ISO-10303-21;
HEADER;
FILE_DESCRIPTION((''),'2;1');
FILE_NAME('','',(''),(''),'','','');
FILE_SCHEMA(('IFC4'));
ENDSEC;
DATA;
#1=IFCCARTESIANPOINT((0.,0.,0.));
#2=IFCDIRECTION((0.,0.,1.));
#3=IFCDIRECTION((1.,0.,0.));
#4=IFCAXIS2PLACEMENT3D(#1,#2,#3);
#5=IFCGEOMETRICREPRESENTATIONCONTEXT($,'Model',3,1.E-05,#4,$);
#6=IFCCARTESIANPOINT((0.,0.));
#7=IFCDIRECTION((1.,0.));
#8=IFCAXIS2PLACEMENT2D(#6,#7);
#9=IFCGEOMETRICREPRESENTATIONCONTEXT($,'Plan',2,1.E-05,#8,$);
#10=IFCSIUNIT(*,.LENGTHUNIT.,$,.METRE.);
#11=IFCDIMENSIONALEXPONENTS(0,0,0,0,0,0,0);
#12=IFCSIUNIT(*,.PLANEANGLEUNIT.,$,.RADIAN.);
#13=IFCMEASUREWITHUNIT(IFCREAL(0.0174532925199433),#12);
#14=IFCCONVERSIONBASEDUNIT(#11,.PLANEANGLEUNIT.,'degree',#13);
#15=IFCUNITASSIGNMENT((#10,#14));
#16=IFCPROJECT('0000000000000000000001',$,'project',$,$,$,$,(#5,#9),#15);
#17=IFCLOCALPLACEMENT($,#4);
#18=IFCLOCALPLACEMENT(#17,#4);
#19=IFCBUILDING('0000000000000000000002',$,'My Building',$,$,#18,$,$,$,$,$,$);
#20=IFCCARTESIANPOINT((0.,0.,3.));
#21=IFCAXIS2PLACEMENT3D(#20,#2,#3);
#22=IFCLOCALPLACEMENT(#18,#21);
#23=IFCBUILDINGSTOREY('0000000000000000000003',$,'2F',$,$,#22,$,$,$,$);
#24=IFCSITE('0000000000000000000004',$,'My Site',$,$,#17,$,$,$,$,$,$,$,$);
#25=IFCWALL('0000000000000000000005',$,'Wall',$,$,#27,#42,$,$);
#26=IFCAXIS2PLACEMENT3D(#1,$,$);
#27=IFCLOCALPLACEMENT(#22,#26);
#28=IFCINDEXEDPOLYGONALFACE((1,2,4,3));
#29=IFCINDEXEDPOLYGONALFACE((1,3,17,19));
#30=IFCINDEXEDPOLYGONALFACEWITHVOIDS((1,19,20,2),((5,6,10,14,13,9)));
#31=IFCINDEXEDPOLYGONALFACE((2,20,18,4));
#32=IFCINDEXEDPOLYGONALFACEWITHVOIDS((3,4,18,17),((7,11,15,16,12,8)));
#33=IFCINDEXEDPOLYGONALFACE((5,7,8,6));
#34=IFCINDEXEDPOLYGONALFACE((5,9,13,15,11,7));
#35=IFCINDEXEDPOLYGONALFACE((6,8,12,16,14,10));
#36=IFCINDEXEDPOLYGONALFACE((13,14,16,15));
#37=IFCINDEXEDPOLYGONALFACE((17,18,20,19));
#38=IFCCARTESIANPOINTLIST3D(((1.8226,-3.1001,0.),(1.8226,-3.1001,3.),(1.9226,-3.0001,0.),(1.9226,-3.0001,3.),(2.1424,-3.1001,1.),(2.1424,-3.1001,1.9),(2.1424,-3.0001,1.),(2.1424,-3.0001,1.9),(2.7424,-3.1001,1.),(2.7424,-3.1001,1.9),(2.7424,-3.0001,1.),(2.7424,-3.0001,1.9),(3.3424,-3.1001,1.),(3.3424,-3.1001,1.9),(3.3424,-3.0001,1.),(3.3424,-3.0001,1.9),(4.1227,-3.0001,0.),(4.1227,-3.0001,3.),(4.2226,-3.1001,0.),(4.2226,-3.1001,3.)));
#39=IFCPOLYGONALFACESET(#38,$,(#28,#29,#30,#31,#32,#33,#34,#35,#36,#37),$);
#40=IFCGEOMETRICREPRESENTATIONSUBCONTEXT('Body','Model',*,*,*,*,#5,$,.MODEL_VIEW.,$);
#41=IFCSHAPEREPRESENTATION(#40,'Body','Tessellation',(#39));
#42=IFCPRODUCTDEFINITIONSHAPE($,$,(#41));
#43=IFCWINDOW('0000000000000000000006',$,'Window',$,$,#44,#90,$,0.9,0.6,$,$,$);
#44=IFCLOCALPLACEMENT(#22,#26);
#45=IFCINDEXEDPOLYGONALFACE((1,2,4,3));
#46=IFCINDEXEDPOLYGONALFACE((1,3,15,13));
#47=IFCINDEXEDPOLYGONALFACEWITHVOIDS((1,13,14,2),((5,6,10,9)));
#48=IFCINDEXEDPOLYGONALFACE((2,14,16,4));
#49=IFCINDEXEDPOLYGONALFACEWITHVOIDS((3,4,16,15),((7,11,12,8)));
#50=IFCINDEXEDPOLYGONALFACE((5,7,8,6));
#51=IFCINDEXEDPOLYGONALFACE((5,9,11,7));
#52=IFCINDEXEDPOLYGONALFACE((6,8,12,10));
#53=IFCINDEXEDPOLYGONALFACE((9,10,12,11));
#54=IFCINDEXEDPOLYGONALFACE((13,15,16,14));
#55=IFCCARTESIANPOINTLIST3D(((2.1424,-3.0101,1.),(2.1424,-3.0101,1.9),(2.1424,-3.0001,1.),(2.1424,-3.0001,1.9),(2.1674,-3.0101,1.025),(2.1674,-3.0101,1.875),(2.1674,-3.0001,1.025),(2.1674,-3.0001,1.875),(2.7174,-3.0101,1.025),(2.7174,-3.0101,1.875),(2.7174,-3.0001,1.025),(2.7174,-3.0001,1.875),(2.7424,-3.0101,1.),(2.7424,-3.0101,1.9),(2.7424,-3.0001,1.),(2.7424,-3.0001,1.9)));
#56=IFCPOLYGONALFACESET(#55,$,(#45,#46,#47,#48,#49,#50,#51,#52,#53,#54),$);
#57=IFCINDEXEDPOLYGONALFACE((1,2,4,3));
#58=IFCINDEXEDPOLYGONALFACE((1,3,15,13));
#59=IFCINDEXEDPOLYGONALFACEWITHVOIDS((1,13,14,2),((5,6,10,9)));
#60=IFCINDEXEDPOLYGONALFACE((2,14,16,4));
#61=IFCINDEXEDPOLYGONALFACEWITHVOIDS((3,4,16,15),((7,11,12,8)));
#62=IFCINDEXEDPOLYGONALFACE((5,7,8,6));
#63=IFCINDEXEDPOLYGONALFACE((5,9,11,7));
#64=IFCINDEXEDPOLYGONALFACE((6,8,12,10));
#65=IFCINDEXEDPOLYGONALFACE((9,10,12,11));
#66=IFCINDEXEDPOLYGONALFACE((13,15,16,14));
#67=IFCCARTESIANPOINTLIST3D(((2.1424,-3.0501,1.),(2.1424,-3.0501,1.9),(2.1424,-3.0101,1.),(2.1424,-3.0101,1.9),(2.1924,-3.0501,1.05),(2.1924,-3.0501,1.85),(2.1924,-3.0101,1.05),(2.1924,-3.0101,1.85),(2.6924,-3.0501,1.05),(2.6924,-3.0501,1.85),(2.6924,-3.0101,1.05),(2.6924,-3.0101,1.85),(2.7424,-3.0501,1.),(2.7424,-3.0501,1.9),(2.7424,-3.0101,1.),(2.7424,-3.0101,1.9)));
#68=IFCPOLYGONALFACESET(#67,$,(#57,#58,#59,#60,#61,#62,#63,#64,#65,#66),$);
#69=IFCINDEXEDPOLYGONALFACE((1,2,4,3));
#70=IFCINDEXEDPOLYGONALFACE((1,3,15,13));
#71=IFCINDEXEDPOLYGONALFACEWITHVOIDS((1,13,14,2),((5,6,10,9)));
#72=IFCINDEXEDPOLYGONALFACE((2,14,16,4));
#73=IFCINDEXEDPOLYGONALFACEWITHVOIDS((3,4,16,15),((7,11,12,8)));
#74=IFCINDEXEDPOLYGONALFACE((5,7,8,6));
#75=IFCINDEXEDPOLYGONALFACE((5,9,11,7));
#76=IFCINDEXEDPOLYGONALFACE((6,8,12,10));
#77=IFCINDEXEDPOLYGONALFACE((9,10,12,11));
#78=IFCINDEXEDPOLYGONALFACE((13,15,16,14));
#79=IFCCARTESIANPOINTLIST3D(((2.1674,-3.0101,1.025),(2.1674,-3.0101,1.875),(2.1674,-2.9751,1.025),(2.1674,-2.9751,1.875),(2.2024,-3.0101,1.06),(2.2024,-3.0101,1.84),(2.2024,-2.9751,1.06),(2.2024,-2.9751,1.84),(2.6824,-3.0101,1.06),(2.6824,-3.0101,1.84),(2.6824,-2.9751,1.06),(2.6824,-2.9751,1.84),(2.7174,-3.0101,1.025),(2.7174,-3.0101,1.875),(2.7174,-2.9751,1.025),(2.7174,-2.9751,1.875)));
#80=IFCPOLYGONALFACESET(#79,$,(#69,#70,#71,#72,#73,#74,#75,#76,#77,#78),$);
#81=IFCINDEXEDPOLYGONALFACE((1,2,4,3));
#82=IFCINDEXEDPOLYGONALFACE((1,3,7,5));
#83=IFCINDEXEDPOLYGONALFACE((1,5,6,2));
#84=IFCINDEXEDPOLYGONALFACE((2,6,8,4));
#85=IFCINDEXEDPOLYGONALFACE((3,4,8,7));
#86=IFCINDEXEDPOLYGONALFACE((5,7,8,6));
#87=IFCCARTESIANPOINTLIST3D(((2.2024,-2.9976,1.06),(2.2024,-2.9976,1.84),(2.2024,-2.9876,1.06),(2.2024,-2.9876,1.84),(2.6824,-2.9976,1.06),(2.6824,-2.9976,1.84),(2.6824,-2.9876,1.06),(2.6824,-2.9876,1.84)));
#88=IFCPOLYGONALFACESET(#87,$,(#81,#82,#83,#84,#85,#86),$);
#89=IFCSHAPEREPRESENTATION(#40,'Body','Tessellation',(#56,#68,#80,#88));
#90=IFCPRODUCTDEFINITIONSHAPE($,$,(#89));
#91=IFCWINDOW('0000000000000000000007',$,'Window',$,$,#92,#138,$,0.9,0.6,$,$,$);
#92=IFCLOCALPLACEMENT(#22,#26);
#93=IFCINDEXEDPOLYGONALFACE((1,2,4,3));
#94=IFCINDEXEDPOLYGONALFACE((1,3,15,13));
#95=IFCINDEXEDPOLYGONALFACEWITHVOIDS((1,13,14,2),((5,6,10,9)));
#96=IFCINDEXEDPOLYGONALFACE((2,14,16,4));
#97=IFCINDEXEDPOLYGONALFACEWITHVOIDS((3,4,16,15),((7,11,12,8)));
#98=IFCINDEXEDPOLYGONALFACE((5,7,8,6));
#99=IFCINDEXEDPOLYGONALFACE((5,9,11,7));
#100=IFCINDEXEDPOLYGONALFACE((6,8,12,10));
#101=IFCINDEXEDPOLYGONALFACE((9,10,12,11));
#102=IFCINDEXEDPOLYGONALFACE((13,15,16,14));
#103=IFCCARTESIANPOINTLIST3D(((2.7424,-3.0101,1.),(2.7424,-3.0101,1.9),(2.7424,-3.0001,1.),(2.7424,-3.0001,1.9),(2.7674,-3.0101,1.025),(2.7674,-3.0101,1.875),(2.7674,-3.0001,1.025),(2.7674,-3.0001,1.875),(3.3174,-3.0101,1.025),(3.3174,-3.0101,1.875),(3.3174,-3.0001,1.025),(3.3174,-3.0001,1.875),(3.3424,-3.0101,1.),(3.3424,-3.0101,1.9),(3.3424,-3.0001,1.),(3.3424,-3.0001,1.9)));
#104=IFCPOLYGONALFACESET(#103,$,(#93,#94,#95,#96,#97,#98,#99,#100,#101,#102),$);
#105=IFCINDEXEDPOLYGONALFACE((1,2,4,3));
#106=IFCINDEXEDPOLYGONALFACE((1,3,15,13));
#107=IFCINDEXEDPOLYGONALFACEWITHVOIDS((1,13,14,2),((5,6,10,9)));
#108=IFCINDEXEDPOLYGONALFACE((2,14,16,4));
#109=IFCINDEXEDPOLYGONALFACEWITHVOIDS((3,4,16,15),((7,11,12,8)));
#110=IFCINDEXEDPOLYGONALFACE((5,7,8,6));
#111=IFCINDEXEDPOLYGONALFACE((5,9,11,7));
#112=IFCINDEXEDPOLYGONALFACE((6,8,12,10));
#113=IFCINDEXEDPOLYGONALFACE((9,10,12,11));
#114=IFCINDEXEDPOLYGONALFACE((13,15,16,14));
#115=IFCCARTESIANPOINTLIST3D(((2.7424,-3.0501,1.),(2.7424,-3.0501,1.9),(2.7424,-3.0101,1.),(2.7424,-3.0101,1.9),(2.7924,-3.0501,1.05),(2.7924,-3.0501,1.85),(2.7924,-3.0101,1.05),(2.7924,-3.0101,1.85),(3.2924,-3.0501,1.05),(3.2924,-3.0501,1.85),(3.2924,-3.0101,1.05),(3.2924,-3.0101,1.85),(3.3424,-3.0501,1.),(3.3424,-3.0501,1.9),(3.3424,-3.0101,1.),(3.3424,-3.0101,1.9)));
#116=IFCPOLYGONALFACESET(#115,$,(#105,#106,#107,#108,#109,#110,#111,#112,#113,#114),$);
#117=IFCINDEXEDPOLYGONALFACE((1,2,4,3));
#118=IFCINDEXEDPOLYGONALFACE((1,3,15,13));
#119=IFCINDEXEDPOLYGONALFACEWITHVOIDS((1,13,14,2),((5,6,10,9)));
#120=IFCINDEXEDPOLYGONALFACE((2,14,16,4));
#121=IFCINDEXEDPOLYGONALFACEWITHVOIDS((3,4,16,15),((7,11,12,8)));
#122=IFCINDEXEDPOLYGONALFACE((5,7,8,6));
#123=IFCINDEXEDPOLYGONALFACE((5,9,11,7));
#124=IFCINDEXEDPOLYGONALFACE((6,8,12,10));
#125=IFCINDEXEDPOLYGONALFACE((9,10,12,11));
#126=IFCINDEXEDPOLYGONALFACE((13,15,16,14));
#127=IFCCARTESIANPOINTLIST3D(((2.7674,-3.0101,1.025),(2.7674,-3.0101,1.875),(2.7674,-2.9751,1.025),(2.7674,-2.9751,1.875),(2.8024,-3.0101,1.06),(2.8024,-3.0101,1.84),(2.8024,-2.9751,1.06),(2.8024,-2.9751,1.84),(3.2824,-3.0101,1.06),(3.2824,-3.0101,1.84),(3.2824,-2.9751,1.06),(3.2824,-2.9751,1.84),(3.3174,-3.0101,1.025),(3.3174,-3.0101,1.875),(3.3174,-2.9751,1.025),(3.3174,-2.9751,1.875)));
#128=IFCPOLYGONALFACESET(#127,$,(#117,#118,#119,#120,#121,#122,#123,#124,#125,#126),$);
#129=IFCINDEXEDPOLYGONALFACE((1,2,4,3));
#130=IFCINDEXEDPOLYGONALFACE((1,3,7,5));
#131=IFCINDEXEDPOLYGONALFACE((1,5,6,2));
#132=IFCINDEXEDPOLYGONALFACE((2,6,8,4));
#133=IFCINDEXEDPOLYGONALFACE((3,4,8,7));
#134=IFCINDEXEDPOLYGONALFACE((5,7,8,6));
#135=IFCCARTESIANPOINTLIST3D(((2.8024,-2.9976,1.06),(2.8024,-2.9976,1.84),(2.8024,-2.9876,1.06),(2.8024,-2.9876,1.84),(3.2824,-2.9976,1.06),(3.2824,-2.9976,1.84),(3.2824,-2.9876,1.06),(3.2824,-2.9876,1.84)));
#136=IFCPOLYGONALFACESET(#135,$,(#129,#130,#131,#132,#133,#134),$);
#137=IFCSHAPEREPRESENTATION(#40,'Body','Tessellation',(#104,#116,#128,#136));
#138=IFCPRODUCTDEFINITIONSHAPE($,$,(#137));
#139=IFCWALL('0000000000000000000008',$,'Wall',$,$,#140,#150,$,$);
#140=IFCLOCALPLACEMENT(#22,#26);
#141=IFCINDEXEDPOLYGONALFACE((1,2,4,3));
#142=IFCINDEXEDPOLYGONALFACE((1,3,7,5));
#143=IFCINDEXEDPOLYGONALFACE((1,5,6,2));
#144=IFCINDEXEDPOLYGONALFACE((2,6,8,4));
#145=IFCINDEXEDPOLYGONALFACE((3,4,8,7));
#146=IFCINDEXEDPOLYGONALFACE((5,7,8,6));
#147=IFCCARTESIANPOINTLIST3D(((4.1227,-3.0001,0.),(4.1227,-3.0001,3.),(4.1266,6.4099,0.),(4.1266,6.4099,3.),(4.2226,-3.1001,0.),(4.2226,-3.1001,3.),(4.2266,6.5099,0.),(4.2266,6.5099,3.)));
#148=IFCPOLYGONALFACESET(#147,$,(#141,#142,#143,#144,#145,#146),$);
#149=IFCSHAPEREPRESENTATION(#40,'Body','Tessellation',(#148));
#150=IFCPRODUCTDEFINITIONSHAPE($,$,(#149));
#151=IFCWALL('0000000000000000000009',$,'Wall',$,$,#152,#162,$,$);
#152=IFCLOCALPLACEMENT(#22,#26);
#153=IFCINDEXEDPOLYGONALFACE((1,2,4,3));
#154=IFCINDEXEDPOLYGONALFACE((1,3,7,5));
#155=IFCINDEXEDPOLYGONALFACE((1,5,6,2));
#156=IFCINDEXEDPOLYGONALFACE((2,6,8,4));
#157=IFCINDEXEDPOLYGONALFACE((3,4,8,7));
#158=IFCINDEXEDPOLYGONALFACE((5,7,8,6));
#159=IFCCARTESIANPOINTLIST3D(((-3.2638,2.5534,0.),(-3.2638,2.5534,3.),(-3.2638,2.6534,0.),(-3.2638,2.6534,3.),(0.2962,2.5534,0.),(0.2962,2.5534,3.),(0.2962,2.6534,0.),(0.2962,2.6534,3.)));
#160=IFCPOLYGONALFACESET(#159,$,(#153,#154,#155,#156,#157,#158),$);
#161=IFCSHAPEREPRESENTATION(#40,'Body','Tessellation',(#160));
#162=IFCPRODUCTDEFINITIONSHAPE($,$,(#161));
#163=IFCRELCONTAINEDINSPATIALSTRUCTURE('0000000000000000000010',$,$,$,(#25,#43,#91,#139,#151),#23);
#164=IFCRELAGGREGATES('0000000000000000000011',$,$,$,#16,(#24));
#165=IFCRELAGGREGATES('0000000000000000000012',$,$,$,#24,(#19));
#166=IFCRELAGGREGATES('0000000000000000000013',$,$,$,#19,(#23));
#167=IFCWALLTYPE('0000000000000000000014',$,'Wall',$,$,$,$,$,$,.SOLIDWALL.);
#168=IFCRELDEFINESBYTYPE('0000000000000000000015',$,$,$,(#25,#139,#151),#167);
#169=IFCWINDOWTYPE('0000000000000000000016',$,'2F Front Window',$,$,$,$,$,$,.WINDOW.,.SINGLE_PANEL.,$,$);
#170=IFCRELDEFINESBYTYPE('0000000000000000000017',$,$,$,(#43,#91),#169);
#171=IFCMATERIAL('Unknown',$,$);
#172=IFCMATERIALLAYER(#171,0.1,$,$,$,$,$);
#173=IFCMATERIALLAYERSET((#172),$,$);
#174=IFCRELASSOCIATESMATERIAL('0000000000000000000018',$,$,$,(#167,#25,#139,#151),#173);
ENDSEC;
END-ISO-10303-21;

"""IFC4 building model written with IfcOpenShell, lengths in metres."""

from ifc_helpers import new_model, entity, si_unit, converted_unit, frame, origin_with_axes, origin_2d_with_axis, place, context, subcontext, project, spatial, line, indexed_curve, outline, extrude, shape, source, transform, mapped, material, layer, layer_set, layer_usage, type_object, type_shapes, element, fill, save


model = new_model("IFC4")

# Units and contexts
model_context = context("Model", 3, precision=1e-05, world=origin_with_axes())
plan_context = context("Plan", 2, precision=1e-05, world=origin_2d_with_axis())
body_context_1 = subcontext(model_context, "Body", "Model", "MODEL_VIEW")
body_context_2 = subcontext(plan_context, "Body", "Plan", "PLAN_VIEW")
ifc_project = project(units=[si_unit("LENGTHUNIT", "METRE"), converted_unit("PLANEANGLEUNIT", "degree", entity("IfcReal", 0.0174532925199433), si_unit("PLANEANGLEUNIT", "RADIAN"), dimensions=[0, 0, 0, 0, 0, 0, 0])], contexts=[model_context, plan_context])

# Site, building, storey
site_placement = place(None, origin_with_axes())
site = spatial("IfcSite", under=ifc_project, at=site_placement, Name="My Site")
building_placement = place(site_placement, origin_with_axes())
building = spatial("IfcBuilding", under=site, at=building_placement, Name="My Building")
storey_placement = place(building_placement, frame((0.0, 0.0, 3.0), z_axis=(0.0, 0.0, 1.0), x_axis=(1.0, 0.0, 0.0)))
storey = spatial("IfcBuildingStorey", under=building, at=storey_placement, Name="2F")

# Shared definitions
ifc_material = material(Name="Unknown")

# Wall, openings, windows
ifc_layer_1 = layer(ifc_material, 0.1)
ifc_layer_set_1 = layer_set([ifc_layer_1])
ifc_layer_usage_1 = layer_usage(ifc_layer_set_1, "AXIS2", "POSITIVE", 0.0)
wall_type = type_object("IfcWallType", Name="Wall", PredefinedType="SOLIDWALL", material=ifc_layer_set_1)
wall_1_placement = place(storey_placement, frame((1.8226, -3.1001, 0.0), z_axis=(0.0, 0.0, 1.0), x_axis=(1.0, 0.0, 0.0)))
wall_1 = element("IfcWall", 1, at=wall_1_placement, inside=storey, type_object=wall_type, material=ifc_layer_usage_1, Name="Wall", context=body_context_1, shape_type="SweptSolid", body=[
    extrude(outline(indexed_curve([(0.0, 0.0), (0.1, 0.1), (2.3, 0.1), (2.4, 0.0)], segments=[line(1, 2, 3, 4, 1)])), origin_with_axes(), (0.0, 0.0, 1.0), 3.0),
])
shared_shape_1 = source(origin_with_axes(), body_context_1, "Body", "SweptSolid", [
    extrude(outline(indexed_curve([(0.0, 0.0), (0.6, 0.0), (0.6, 0.9), (0.0, 0.9)], segments=[line(1, 2, 3, 4, 1)])), frame((0.0, -0.6, 0.0), z_axis=(0.0, -1.0, 0.0), x_axis=(1.0, 0.0, 0.0)), (0.0, 0.0, -1.0), 1.2),
])
opening_1_placement = place(wall_1_placement, frame((0.3197, 0.0, 1.0), z_axis=(0.0, 0.0, 1.0), x_axis=(1.0, 0.0, 0.0)))
opening_1 = element("IfcOpeningElement", 2, at=opening_1_placement, cuts=wall_1, PredefinedType="OPENING", context=body_context_1, shape_type="MappedRepresentation", body=[
    mapped(shared_shape_1, transform((0.0, 0.0, 0.0), x_axis=(1.0, 0.0, 0.0), y_axis=(0.0, 1.0, 0.0), z_axis=(0.0, 0.0, 1.0), scale=1.0)),
])
opening_2_placement = place(wall_1_placement, frame((0.9197, 0.0, 1.0), z_axis=(0.0, 0.0, 1.0), x_axis=(1.0, 0.0, 0.0)))
opening_2 = element("IfcOpeningElement", 3, at=opening_2_placement, cuts=wall_1, PredefinedType="OPENING", context=body_context_1, shape_type="MappedRepresentation", body=[
    mapped(shared_shape_1, transform((0.0, 0.0, 0.0), x_axis=(1.0, 0.0, 0.0), y_axis=(0.0, 1.0, 0.0), z_axis=(0.0, 0.0, 1.0), scale=1.0)),
])
window_type_1 = type_object("IfcWindowType", Name="2F Front Window", PartitioningType="SINGLE_PANEL", PredefinedType="WINDOW")
shared_shape_2 = source(origin_with_axes(), body_context_1, "Body", "SweptSolid", [
    extrude(outline(indexed_curve([(0.0, 0.0), (0.6, 0.0), (0.6, 0.9), (0.0, 0.9)], segments=[line(1, 2, 3, 4, 1)]), holes=[indexed_curve([(0.025, 0.025), (0.575, 0.025), (0.575, 0.875), (0.025, 0.875)], segments=[line(1, 2, 3, 4, 1)])]), frame((0.0, 0.09, 0.0), z_axis=(0.0, -1.0, 0.0), x_axis=(1.0, 0.0, 0.0)), (0.0, 0.0, -1.0), 0.01),
    extrude(outline(indexed_curve([(0.0, 0.0), (0.6, 0.0), (0.6, 0.9), (0.0, 0.9)], segments=[line(1, 2, 3, 4, 1)]), holes=[indexed_curve([(0.05, 0.05), (0.55, 0.05), (0.55, 0.85), (0.05, 0.85)], segments=[line(1, 2, 3, 4, 1)])]), frame((0.0, 0.05, 0.0), z_axis=(0.0, -1.0, 0.0), x_axis=(1.0, 0.0, 0.0)), (0.0, 0.0, -1.0), 0.04),
    extrude(outline(indexed_curve([(0.0, 0.0), (0.55, 0.0), (0.55, 0.85), (0.0, 0.85)], segments=[line(1, 2, 3, 4, 1)]), holes=[indexed_curve([(0.035, 0.035), (0.515, 0.035), (0.515, 0.815), (0.035, 0.815)], segments=[line(1, 2, 3, 4, 1)])]), frame((0.025, 0.09, 0.025), z_axis=(0.0, -1.0, 0.0), x_axis=(1.0, 0.0, 0.0)), (0.0, 0.0, -1.0), 0.035),
    extrude(outline(indexed_curve([(0.035, 0.035), (0.515, 0.035), (0.515, 0.815), (0.035, 0.815)], segments=[line(1, 2, 3, 4, 1)])), frame((0.025, 0.1025, 0.025), z_axis=(0.0, -1.0, 0.0), x_axis=(1.0, 0.0, 0.0)), (0.0, 0.0, -1.0), 0.01),
])
shared_shape_3 = source(origin_with_axes(), body_context_2, "Body", "Curve2D", [
    entity("IfcIndexedPolyCurve", entity("IfcCartesianPointList2D", [[0.05, 0.05], [0.55, 0.05]])),
    entity("IfcIndexedPolyCurve", entity("IfcCartesianPointList2D", [[0.0, 0.1], [0.025, 0.1], [0.025, 0.09], [0.05, 0.09], [0.05, 0.05], [0.0, 0.05]]), [entity("IfcLineIndex", [1, 2, 3, 4, 5, 6, 1])]),
    entity("IfcIndexedPolyCurve", entity("IfcCartesianPointList2D", [[0.6, 0.1], [0.575, 0.1], [0.575, 0.09], [0.55, 0.09], [0.55, 0.05], [0.6, 0.05]]), [entity("IfcLineIndex", [1, 2, 3, 4, 5, 6, 1])]),
    entity("IfcIndexedPolyCurve", entity("IfcCartesianPointList2D", [[0.025, 0.09], [0.06, 0.09], [0.06, 0.125], [0.025, 0.125]]), [entity("IfcLineIndex", [1, 2, 3, 4, 1])]),
    entity("IfcIndexedPolyCurve", entity("IfcCartesianPointList2D", [[0.575, 0.09], [0.54, 0.09], [0.54, 0.125], [0.575, 0.125]]), [entity("IfcLineIndex", [1, 2, 3, 4, 1])]),
    entity("IfcIndexedPolyCurve", entity("IfcCartesianPointList2D", [[0.06, 0.09], [0.54, 0.09]])),
    entity("IfcIndexedPolyCurve", entity("IfcCartesianPointList2D", [[0.06, 0.125], [0.54, 0.125]])),
    entity("IfcIndexedPolyCurve", entity("IfcCartesianPointList2D", [[0.06, 0.1075], [0.54, 0.1075]])),
])
type_shapes(window_type_1, [shared_shape_2, shared_shape_3])
window_1_placement = place(opening_1_placement, origin_with_axes())
window_1 = element("IfcWindow", 4, at=window_1_placement, inside=storey, type_object=window_type_1, Name="Window", OverallHeight=0.9, OverallWidth=0.6, shapes=[
    shape(body_context_1, "Body", "MappedRepresentation", [mapped(shared_shape_2, transform((0.0, 0.0, 0.0), x_axis=(1.0, 0.0, 0.0), y_axis=(0.0, 1.0, 0.0), z_axis=(0.0, 0.0, 1.0), scale=1.0))]),
    shape(body_context_2, "Body", "MappedRepresentation", [mapped(shared_shape_3, transform((0.0, 0.0, 0.0), x_axis=(1.0, 0.0, 0.0), y_axis=(0.0, 1.0, 0.0), z_axis=(0.0, 0.0, 1.0), scale=1.0))]),
])
fill(opening_1, window_1)
window_2_placement = place(opening_2_placement, origin_with_axes())
window_2 = element("IfcWindow", 5, at=window_2_placement, inside=storey, type_object=window_type_1, Name="Window", OverallHeight=0.9, OverallWidth=0.6, shapes=[
    shape(body_context_1, "Body", "MappedRepresentation", [mapped(shared_shape_2, transform((0.0, 0.0, 0.0), x_axis=(1.0, 0.0, 0.0), y_axis=(0.0, 1.0, 0.0), z_axis=(0.0, 0.0, 1.0), scale=1.0))]),
    shape(body_context_2, "Body", "MappedRepresentation", [mapped(shared_shape_3, transform((0.0, 0.0, 0.0), x_axis=(1.0, 0.0, 0.0), y_axis=(0.0, 1.0, 0.0), z_axis=(0.0, 0.0, 1.0), scale=1.0))]),
])
fill(opening_2, window_2)

# Walls
ifc_layer_usage_2 = layer_usage(ifc_layer_set_1, "AXIS2", "POSITIVE", 0.0)
wall_2_placement = place(storey_placement, frame((4.2226, -3.1001, 0.0), z_axis=(0.0, 0.0, 1.0), x_axis=(0.000415, 1.0, 0.0)))
element("IfcWall", 6, at=wall_2_placement, inside=storey, type_object=wall_type, material=ifc_layer_usage_2, Name="Wall", context=body_context_1, shape_type="SweptSolid", body=[
    extrude(outline(indexed_curve([(0.0, 0.0), (0.1, 0.1), (9.51, 0.1), (9.61, 0.0)], segments=[line(1, 2, 3, 4, 1)])), origin_with_axes(), (0.0, 0.0, 1.0), 3.0),
])
ifc_layer_usage_3 = layer_usage(ifc_layer_set_1, "AXIS2", "POSITIVE", 0.0)
wall_3_placement = place(storey_placement, frame((-3.2638, 2.5534, 0.0), z_axis=(0.0, 0.0, 1.0), x_axis=(1.0, 0.0, 0.0)))
element("IfcWall", 7, at=wall_3_placement, inside=storey, type_object=wall_type, material=ifc_layer_usage_3, Name="Wall", context=body_context_1, shape_type="SweptSolid", body=[
    extrude(outline(indexed_curve([(0.0, 0.0), (0.0, 0.1), (3.56, 0.1), (3.56, 0.0)], segments=[line(1, 2, 3, 4, 1)])), origin_with_axes(), (0.0, 0.0, 1.0), 3.0),
])

save(model, "model.ifc")
